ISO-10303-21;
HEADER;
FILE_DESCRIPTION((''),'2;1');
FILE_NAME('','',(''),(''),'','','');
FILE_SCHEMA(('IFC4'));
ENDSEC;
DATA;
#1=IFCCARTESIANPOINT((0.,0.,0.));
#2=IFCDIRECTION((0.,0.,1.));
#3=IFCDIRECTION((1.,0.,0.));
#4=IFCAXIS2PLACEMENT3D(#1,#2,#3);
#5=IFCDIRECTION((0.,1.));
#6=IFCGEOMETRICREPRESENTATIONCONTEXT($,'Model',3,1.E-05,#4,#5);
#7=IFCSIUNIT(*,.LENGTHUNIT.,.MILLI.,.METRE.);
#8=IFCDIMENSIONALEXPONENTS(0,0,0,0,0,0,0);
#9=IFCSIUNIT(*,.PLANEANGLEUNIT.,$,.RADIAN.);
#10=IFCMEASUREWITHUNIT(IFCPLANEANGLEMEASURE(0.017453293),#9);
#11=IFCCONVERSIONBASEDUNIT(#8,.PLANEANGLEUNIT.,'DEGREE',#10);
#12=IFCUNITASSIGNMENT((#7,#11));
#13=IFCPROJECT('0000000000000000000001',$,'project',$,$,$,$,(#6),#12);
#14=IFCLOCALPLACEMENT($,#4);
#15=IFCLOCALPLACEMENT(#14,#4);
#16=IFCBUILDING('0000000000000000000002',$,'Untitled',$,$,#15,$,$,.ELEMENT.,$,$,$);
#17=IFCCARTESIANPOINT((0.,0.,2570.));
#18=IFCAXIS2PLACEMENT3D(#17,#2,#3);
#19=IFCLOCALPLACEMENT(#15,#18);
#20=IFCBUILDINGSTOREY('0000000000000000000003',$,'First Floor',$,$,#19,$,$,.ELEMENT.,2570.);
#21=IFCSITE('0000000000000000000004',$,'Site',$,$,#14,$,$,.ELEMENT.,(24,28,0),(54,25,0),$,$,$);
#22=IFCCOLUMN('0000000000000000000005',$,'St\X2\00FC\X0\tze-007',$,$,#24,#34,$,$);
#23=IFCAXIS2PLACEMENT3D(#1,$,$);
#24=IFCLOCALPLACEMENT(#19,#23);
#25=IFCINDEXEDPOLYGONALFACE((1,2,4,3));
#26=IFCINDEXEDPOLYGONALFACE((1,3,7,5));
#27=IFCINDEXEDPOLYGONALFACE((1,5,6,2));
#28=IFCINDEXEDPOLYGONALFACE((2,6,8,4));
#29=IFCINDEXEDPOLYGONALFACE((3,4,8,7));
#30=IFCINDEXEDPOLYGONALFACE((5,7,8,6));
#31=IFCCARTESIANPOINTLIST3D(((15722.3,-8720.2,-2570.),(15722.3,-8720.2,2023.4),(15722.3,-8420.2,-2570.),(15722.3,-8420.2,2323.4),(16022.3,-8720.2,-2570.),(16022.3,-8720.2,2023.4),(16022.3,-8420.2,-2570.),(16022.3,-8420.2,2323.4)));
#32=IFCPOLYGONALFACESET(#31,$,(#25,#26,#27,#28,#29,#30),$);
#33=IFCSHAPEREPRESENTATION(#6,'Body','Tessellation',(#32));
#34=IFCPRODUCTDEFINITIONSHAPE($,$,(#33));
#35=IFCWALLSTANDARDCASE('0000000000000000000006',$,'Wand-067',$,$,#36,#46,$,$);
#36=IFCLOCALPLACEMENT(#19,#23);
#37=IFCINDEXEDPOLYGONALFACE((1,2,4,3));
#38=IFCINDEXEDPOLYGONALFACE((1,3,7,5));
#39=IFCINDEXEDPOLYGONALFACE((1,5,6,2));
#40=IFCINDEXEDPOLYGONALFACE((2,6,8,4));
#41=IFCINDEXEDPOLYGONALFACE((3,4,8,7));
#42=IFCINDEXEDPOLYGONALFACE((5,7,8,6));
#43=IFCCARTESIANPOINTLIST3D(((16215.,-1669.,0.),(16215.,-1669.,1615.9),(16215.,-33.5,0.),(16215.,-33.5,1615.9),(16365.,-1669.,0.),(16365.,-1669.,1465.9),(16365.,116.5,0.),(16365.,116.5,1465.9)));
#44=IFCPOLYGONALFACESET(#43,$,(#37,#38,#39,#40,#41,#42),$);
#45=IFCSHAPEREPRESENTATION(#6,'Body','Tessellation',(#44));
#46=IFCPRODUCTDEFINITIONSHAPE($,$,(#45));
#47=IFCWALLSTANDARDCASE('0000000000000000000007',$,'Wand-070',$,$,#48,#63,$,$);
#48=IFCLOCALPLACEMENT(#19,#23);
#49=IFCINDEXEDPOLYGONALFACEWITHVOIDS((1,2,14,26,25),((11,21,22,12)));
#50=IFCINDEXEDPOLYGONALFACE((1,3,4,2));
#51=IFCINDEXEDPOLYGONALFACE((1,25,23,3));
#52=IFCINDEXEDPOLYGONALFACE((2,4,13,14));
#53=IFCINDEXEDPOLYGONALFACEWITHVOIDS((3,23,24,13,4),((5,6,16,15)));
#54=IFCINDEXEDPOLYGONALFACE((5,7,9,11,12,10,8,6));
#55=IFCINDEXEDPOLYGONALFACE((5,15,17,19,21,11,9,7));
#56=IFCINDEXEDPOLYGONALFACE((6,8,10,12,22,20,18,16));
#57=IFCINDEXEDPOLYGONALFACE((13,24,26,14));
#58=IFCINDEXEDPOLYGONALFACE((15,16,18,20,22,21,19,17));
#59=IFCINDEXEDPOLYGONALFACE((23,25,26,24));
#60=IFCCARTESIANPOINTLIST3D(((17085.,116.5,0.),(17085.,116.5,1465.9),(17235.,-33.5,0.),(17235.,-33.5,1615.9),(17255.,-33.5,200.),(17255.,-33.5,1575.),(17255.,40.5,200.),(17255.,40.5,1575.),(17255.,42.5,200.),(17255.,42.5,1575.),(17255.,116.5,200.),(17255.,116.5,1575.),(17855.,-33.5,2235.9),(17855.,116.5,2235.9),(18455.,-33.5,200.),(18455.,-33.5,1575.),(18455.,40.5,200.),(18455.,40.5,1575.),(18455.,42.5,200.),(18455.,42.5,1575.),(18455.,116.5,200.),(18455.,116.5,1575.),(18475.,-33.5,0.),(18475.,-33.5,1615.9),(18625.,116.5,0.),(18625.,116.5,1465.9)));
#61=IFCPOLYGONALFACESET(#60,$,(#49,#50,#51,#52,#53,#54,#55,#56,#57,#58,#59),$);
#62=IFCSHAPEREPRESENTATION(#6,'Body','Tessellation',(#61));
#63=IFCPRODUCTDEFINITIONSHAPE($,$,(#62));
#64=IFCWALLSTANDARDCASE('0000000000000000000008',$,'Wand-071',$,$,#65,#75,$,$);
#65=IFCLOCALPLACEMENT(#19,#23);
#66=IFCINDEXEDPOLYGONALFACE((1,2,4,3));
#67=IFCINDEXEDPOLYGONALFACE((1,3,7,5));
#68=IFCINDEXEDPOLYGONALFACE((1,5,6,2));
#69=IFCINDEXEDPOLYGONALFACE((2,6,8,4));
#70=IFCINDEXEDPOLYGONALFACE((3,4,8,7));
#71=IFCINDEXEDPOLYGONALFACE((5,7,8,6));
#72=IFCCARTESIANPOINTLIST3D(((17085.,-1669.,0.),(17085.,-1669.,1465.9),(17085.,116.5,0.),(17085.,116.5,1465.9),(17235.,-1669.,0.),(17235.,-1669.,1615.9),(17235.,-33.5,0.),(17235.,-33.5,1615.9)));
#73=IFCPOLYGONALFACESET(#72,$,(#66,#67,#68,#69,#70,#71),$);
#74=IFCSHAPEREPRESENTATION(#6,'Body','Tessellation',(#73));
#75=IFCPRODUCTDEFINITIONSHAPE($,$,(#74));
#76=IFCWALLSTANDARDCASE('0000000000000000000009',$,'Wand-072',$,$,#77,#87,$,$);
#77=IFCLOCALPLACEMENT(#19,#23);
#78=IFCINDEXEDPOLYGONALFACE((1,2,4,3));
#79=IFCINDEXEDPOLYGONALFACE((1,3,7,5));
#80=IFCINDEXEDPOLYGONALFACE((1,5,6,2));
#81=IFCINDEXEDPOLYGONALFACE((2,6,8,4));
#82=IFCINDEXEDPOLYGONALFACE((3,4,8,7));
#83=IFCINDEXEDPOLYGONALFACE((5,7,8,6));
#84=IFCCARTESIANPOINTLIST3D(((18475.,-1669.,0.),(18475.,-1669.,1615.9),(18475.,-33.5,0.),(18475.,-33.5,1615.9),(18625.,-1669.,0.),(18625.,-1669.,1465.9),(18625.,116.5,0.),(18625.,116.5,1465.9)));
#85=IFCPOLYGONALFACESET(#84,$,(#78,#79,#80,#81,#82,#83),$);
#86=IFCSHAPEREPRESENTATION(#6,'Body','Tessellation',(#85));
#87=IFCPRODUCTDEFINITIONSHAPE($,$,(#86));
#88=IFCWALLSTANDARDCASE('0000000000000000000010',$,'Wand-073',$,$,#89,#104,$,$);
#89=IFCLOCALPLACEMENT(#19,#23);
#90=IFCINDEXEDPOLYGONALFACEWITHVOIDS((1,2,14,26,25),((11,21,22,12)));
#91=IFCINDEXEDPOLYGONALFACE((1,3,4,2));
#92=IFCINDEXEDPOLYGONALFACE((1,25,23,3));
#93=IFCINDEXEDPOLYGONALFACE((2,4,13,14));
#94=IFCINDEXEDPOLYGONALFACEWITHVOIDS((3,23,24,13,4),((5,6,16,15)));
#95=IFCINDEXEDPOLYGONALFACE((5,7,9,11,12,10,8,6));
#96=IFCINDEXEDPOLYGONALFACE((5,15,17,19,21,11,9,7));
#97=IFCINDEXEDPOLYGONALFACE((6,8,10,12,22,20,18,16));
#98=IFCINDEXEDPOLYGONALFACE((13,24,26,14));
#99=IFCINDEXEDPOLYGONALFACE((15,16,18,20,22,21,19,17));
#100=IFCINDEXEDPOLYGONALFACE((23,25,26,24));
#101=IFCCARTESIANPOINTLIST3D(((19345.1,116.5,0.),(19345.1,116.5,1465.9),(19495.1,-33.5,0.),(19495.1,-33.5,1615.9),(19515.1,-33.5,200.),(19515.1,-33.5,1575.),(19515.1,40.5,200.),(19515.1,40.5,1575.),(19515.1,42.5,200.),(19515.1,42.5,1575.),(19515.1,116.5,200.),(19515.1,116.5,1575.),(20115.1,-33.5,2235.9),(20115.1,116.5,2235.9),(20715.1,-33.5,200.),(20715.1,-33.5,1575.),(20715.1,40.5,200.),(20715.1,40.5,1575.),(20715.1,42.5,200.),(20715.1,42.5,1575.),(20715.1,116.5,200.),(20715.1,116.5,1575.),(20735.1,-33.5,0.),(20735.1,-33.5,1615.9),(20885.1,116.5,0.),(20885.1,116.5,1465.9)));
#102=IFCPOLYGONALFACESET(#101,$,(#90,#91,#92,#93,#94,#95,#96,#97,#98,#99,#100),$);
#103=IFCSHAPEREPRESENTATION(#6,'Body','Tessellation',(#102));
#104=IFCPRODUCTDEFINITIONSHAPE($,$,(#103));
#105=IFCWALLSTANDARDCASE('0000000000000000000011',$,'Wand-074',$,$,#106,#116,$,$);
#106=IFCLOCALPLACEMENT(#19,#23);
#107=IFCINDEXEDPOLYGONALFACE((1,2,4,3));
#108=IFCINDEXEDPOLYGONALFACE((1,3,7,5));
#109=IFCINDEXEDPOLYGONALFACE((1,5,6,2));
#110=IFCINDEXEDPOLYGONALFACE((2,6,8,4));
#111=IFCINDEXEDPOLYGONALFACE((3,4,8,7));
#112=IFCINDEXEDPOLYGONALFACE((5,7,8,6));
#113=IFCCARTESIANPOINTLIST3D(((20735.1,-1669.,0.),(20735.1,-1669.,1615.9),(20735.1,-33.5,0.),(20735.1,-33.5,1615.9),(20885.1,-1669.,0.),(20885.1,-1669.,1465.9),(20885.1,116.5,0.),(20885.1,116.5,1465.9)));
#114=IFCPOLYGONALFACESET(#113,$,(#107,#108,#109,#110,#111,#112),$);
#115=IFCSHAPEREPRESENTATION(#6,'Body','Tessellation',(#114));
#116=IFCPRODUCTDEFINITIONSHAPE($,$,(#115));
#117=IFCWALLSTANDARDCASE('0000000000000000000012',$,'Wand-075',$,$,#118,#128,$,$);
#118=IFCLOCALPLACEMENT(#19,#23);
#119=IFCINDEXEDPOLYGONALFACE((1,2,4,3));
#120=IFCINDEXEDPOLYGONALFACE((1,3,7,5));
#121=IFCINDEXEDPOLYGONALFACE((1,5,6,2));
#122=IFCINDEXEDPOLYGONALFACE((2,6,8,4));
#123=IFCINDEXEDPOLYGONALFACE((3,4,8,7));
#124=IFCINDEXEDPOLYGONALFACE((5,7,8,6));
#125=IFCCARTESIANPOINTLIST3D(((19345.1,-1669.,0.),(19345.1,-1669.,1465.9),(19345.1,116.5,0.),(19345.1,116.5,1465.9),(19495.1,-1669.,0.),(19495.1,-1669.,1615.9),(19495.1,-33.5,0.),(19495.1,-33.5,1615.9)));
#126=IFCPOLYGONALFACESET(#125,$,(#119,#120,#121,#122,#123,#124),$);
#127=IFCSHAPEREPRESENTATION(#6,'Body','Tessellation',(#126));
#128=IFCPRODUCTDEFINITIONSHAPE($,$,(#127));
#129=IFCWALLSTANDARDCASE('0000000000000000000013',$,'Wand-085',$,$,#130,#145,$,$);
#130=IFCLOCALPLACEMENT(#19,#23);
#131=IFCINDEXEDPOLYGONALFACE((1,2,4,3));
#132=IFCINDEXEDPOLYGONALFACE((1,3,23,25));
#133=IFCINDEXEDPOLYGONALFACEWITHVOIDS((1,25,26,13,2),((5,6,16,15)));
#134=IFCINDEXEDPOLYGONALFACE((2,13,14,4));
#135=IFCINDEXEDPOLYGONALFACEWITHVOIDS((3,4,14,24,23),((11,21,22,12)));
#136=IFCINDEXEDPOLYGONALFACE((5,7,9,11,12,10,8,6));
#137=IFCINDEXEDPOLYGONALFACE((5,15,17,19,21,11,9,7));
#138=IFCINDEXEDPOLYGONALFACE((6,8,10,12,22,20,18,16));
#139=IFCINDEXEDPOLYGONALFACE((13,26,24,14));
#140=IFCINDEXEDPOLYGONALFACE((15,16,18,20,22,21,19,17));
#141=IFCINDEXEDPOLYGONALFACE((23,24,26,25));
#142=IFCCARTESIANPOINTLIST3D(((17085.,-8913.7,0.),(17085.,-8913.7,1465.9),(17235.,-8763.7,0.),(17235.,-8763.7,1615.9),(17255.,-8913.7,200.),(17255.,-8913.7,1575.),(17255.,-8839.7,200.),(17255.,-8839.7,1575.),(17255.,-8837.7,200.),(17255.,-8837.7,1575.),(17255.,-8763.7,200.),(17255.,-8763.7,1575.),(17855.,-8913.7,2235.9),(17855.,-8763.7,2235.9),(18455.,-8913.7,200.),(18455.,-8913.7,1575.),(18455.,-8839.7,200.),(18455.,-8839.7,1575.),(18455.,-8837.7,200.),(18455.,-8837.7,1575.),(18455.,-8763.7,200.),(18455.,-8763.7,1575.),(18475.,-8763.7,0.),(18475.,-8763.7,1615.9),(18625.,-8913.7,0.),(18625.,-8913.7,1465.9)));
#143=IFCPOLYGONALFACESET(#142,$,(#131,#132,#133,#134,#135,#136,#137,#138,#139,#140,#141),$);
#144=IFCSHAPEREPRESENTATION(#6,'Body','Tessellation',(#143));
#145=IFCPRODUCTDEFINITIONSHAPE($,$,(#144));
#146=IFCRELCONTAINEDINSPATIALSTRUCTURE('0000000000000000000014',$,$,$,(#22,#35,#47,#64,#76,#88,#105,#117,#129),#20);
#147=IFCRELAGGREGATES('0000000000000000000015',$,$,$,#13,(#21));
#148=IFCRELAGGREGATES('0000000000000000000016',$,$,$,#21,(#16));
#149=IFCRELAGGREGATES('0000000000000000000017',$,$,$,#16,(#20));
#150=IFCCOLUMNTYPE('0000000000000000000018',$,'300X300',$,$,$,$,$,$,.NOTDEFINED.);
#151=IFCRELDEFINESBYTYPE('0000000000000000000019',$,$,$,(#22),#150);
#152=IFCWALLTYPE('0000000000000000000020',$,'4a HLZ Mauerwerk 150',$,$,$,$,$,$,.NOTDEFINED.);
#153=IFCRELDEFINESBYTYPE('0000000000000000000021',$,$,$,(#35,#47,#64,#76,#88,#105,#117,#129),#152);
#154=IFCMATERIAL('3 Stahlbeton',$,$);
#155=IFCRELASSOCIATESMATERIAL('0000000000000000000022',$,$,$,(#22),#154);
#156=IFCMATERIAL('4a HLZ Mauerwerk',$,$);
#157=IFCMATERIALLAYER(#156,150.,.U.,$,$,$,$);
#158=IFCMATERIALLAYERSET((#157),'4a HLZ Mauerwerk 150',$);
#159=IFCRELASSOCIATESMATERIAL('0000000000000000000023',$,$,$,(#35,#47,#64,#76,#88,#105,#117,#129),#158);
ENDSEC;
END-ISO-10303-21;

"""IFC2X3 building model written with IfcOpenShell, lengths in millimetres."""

from ifc_helpers import new_model, entity, si_unit, converted_unit, direction, frame, origin_with_axes, origin_2d_with_axis, place, context, project, spatial, polyline, rectangle, outline, extrude, clip, halfspace, bounded_halfspace, material, layer, layer_set, layer_usage, type_object, element, save


model = new_model("IFC2X3")

# Units and contexts
model_context = context("Model", 3, precision=1e-05, world=origin_with_axes(), true_north=direction((0.0, 1.0)))
ifc_project = project(units=[si_unit("LENGTHUNIT", "METRE", prefix="MILLI"), converted_unit("PLANEANGLEUNIT", "DEGREE", entity("IfcPlaneAngleMeasure", 0.017453293), si_unit("PLANEANGLEUNIT", "RADIAN"), dimensions=[0, 0, 0, 0, 0, 0, 0])], contexts=[model_context])

# Site, building, storey
site_placement = place(None, origin_with_axes())
site = spatial("IfcSite", under=ifc_project, at=site_placement, Name="Site", CompositionType="ELEMENT", RefLatitude=(24, 28, 0), RefLongitude=(54, 25, 0))
building_placement = place(site_placement, origin_with_axes())
building = spatial("IfcBuilding", under=site, at=building_placement, Name="Untitled", CompositionType="ELEMENT")
storey_placement = place(building_placement, frame((0.0, 0.0, 2570.0), z_axis=(0.0, 0.0, 1.0), x_axis=(1.0, 0.0, 0.0)))
storey = spatial("IfcBuildingStorey", under=building, at=storey_placement, Name="First Floor", CompositionType="ELEMENT", Elevation=2570.0)

# Column
ifc_material_1 = material(Name="3 Stahlbeton")
column_type = type_object("IfcColumnType", Name="300X300", PredefinedType="NOTDEFINED")
column_placement = place(storey_placement, frame((15872.3, -8570.2, -2570.0), z_axis=(0.0, 0.0, 1.0), x_axis=(1.0, 0.0, 0.0)))
element("IfcColumn", 1, at=column_placement, inside=storey, type_object=column_type, material=ifc_material_1, Name="Stütze-007", context=model_context, shape_type="Clipping", body=[
    clip(extrude(rectangle(XDim=300.0, YDim=300.0, at=origin_2d_with_axis()), origin_with_axes(), (0.0, 0.0, 1.0), 7000.0), halfspace(frame((0.0, -2371.7, 2371.7), z_axis=(0.0, 0.707107, -0.707107), x_axis=(0.0, -0.707107, -0.707107)), True)),
])

# Wall
ifc_material_2 = material(Name="4a HLZ Mauerwerk")
ifc_layer_1 = layer(ifc_material_2, 150.0, ventilated="UNKNOWN")
ifc_layer_set_1 = layer_set([ifc_layer_1], Name="4a HLZ Mauerwerk 150")
ifc_layer_usage_1 = layer_usage(ifc_layer_set_1, "AXIS2", "NEGATIVE", 0.0)
wall_type_1 = type_object("IfcWallType", Name="4a HLZ Mauerwerk 150", PredefinedType="NOTDEFINED")
wall_1_placement = place(storey_placement, frame((16365.0, 116.5, 0.0), z_axis=(0.0, 0.0, 1.0), x_axis=(0.0, -1.0, 0.0)))
element("IfcWallStandardCase", 2, at=wall_1_placement, inside=storey, type_object=wall_type_1, material=ifc_layer_usage_1, Name="Wand-067", context=model_context, shape_type="Clipping", body=[
    clip(extrude(outline(polyline([(150.0, -150.0), (1785.6, -150.0), (1785.6, 0.0), (0.0, 0.0), (150.0, -150.0)])), origin_with_axes(), (0.0, 0.0, 1.0), 5316.0), halfspace(frame((0.0, 733.0, 733.0), z_axis=(0.0, -0.707107, -0.707107), x_axis=(0.0, -0.707107, 0.707107)), True)),
])

# Wall, opening
ifc_layer_usage_2 = layer_usage(ifc_layer_set_1, "AXIS2", "NEGATIVE", 0.0)
wall_2_placement = place(storey_placement, frame((17085.0, 116.5, 0.0), z_axis=(0.0, 0.0, 1.0), x_axis=(1.0, 0.0, 0.0)))
wall_2 = element("IfcWallStandardCase", 3, at=wall_2_placement, inside=storey, type_object=wall_type_1, material=ifc_layer_usage_2, Name="Wand-070", context=model_context, shape_type="Clipping", body=[
    clip(clip(extrude(outline(polyline([(150.0, -150.0), (1390.0, -150.0), (1540.0, 0.0), (0.0, 0.0), (150.0, -150.0)])), origin_with_axes(), (0.0, 0.0, 1.0), 5316.0), bounded_halfspace(frame((1503.0, 0.0, 1503.0), z_axis=(-0.707107, 0.0, -0.707107), x_axis=(0.707107, 0.0, -0.707107)), True, origin_with_axes(), polyline([(770.0, -150.0), (1540.0, -150.0), (1540.0, 0.0), (770.0, 0.0), (770.0, -150.0)]))), bounded_halfspace(frame((-733.0, 0.0, 733.0), z_axis=(0.707107, 0.0, -0.707107), x_axis=(0.707107, 0.0, 0.707107)), True, origin_with_axes(), polyline([(0.0, -150.0), (770.0, -150.0), (770.0, 0.0), (0.0, 0.0), (0.0, -150.0)]))),
])
opening_1_placement = place(wall_2_placement, frame((770.0, 0.0, 200.0), z_axis=(0.0, 0.0, 1.0), x_axis=(1.0, 0.0, 0.0)))
element("IfcOpeningElement", 4, at=opening_1_placement, cuts=wall_2, context=model_context, shape_type="SweptSolid", body=[
    extrude(rectangle(XDim=1200.0, YDim=1375.0, at=origin_2d_with_axis()), frame((0.0, 226.0, 687.5), z_axis=(0.0, -1.0, 0.0), x_axis=(1.0, 0.0, 0.0)), (0.0, 0.0, 1.0), 302.0),
    extrude(rectangle(XDim=1200.0, YDim=1375.0, at=origin_2d_with_axis()), frame((0.0, -376.0, 687.5), z_axis=(0.0, 1.0, 0.0), x_axis=(1.0, 0.0, 0.0)), (0.0, 0.0, 1.0), 302.0),
])

# Walls
ifc_layer_usage_3 = layer_usage(ifc_layer_set_1, "AXIS2", "POSITIVE", 0.0)
wall_3_placement = place(storey_placement, frame((17085.0, 116.5, 0.0), z_axis=(0.0, 0.0, 1.0), x_axis=(0.0, -1.0, 0.0)))
element("IfcWallStandardCase", 5, at=wall_3_placement, inside=storey, type_object=wall_type_1, material=ifc_layer_usage_3, Name="Wand-071", context=model_context, shape_type="Clipping", body=[
    clip(extrude(outline(polyline([(0.0, 0.0), (1785.6, 0.0), (1785.6, 150.0), (150.0, 150.0), (0.0, 0.0)])), origin_with_axes(), (0.0, 0.0, 1.0), 5316.0), halfspace(frame((0.0, -733.0, 733.0), z_axis=(0.0, 0.707107, -0.707107), x_axis=(0.0, -0.707107, -0.707107)), True)),
])
ifc_layer_usage_4 = layer_usage(ifc_layer_set_1, "AXIS2", "NEGATIVE", 0.0)
wall_4_placement = place(storey_placement, frame((18625.0, 116.5, 0.0), z_axis=(0.0, 0.0, 1.0), x_axis=(0.0, -1.0, 0.0)))
element("IfcWallStandardCase", 6, at=wall_4_placement, inside=storey, type_object=wall_type_1, material=ifc_layer_usage_4, Name="Wand-072", context=model_context, shape_type="Clipping", body=[
    clip(extrude(outline(polyline([(150.0, -150.0), (1785.6, -150.0), (1785.6, 0.0), (0.0, 0.0), (150.0, -150.0)])), origin_with_axes(), (0.0, 0.0, 1.0), 5316.0), halfspace(frame((0.0, 733.0, 733.0), z_axis=(0.0, -0.707107, -0.707107), x_axis=(0.0, -0.707107, 0.707107)), True)),
])

# Wall, opening
ifc_layer_usage_5 = layer_usage(ifc_layer_set_1, "AXIS2", "NEGATIVE", 0.0)
wall_5_placement = place(storey_placement, frame((19345.1, 116.5, 0.0), z_axis=(0.0, 0.0, 1.0), x_axis=(1.0, 0.0, 0.0)))
wall_5 = element("IfcWallStandardCase", 7, at=wall_5_placement, inside=storey, type_object=wall_type_1, material=ifc_layer_usage_5, Name="Wand-073", context=model_context, shape_type="Clipping", body=[
    clip(clip(extrude(outline(polyline([(150.0, -150.0), (1390.0, -150.0), (1540.0, 0.0), (0.0, 0.0), (150.0, -150.0)])), origin_with_axes(), (0.0, 0.0, 1.0), 5316.0), bounded_halfspace(frame((-733.0, 0.0, 733.0), z_axis=(0.707107, 0.0, -0.707107), x_axis=(0.707107, 0.0, 0.707107)), True, origin_with_axes(), polyline([(0.0, -150.0), (770.0, -150.0), (770.0, 0.0), (0.0, 0.0), (0.0, -150.0)]))), bounded_halfspace(frame((1503.0, 0.0, 1503.0), z_axis=(-0.707107, 0.0, -0.707107), x_axis=(0.707107, 0.0, -0.707107)), True, origin_with_axes(), polyline([(770.0, -150.0), (1540.0, -150.0), (1540.0, 0.0), (770.0, 0.0), (770.0, -150.0)]))),
])
opening_2_placement = place(wall_5_placement, frame((770.0, 0.0, 200.0), z_axis=(0.0, 0.0, 1.0), x_axis=(1.0, 0.0, 0.0)))
element("IfcOpeningElement", 8, at=opening_2_placement, cuts=wall_5, context=model_context, shape_type="SweptSolid", body=[
    extrude(rectangle(XDim=1200.0, YDim=1375.0, at=origin_2d_with_axis()), frame((0.0, 226.0, 687.5), z_axis=(0.0, -1.0, 0.0), x_axis=(1.0, 0.0, 0.0)), (0.0, 0.0, 1.0), 302.0),
    extrude(rectangle(XDim=1200.0, YDim=1375.0, at=origin_2d_with_axis()), frame((0.0, -376.0, 687.5), z_axis=(0.0, 1.0, 0.0), x_axis=(1.0, 0.0, 0.0)), (0.0, 0.0, 1.0), 302.0),
])

# Walls
ifc_layer_usage_6 = layer_usage(ifc_layer_set_1, "AXIS2", "NEGATIVE", 0.0)
wall_6_placement = place(storey_placement, frame((20885.1, 116.5, 0.0), z_axis=(0.0, 0.0, 1.0), x_axis=(0.0, -1.0, 0.0)))
element("IfcWallStandardCase", 9, at=wall_6_placement, inside=storey, type_object=wall_type_1, material=ifc_layer_usage_6, Name="Wand-074", context=model_context, shape_type="Clipping", body=[
    clip(extrude(outline(polyline([(150.0, -150.0), (1785.6, -150.0), (1785.6, 0.0), (0.0, 0.0), (150.0, -150.0)])), origin_with_axes(), (0.0, 0.0, 1.0), 5316.0), halfspace(frame((0.0, 733.0, 733.0), z_axis=(0.0, -0.707107, -0.707107), x_axis=(0.0, -0.707107, 0.707107)), True)),
])
ifc_layer_usage_7 = layer_usage(ifc_layer_set_1, "AXIS2", "POSITIVE", 0.0)
wall_7_placement = place(storey_placement, frame((19345.1, 116.5, 0.0), z_axis=(0.0, 0.0, 1.0), x_axis=(0.0, -1.0, 0.0)))
element("IfcWallStandardCase", 10, at=wall_7_placement, inside=storey, type_object=wall_type_1, material=ifc_layer_usage_7, Name="Wand-075", context=model_context, shape_type="Clipping", body=[
    clip(extrude(outline(polyline([(0.0, 0.0), (1785.6, 0.0), (1785.6, 150.0), (150.0, 150.0), (0.0, 0.0)])), origin_with_axes(), (0.0, 0.0, 1.0), 5316.0), halfspace(frame((0.0, -733.0, 733.0), z_axis=(0.0, 0.707107, -0.707107), x_axis=(0.0, -0.707107, -0.707107)), True)),
])

# Wall, opening
ifc_layer_usage_8 = layer_usage(ifc_layer_set_1, "AXIS2", "POSITIVE", 0.0)
wall_8_placement = place(storey_placement, frame((17085.0, -8913.7, 0.0), z_axis=(0.0, 0.0, 1.0), x_axis=(1.0, 0.0, 0.0)))
wall_8 = element("IfcWallStandardCase", 11, at=wall_8_placement, inside=storey, type_object=wall_type_1, material=ifc_layer_usage_8, Name="Wand-085", context=model_context, shape_type="Clipping", body=[
    clip(clip(extrude(outline(polyline([(0.0, 0.0), (1540.0, 0.0), (1390.0, 150.0), (150.0, 150.0), (0.0, 0.0)])), origin_with_axes(), (0.0, 0.0, 1.0), 5316.0), bounded_halfspace(frame((1503.0, 0.0, 1503.0), z_axis=(-0.707107, 0.0, -0.707107), x_axis=(0.707107, 0.0, -0.707107)), True, origin_with_axes(), polyline([(770.0, 0.0), (1540.0, 0.0), (1540.0, 150.0), (770.0, 150.0), (770.0, 0.0)]))), bounded_halfspace(frame((-733.0, 0.0, 733.0), z_axis=(0.707107, 0.0, -0.707107), x_axis=(0.707107, 0.0, 0.707107)), True, origin_with_axes(), polyline([(0.0, 0.0), (770.0, 0.0), (770.0, 150.0), (0.0, 150.0), (0.0, 0.0)]))),
])
opening_3_placement = place(wall_8_placement, frame((770.0, 0.0, 200.0), z_axis=(0.0, 0.0, 1.0), x_axis=(1.0, 0.0, 0.0)))
element("IfcOpeningElement", 12, at=opening_3_placement, cuts=wall_8, context=model_context, shape_type="SweptSolid", body=[
    extrude(rectangle(XDim=1200.0, YDim=1375.0, at=origin_2d_with_axis()), frame((0.0, -226.0, 687.5), z_axis=(0.0, 1.0, 0.0), x_axis=(1.0, 0.0, 0.0)), (0.0, 0.0, 1.0), 302.0),
    extrude(rectangle(XDim=1200.0, YDim=1375.0, at=origin_2d_with_axis()), frame((0.0, 376.0, 687.5), z_axis=(0.0, -1.0, 0.0), x_axis=(1.0, 0.0, 0.0)), (0.0, 0.0, 1.0), 302.0),
])

save(model, "model.ifc")
